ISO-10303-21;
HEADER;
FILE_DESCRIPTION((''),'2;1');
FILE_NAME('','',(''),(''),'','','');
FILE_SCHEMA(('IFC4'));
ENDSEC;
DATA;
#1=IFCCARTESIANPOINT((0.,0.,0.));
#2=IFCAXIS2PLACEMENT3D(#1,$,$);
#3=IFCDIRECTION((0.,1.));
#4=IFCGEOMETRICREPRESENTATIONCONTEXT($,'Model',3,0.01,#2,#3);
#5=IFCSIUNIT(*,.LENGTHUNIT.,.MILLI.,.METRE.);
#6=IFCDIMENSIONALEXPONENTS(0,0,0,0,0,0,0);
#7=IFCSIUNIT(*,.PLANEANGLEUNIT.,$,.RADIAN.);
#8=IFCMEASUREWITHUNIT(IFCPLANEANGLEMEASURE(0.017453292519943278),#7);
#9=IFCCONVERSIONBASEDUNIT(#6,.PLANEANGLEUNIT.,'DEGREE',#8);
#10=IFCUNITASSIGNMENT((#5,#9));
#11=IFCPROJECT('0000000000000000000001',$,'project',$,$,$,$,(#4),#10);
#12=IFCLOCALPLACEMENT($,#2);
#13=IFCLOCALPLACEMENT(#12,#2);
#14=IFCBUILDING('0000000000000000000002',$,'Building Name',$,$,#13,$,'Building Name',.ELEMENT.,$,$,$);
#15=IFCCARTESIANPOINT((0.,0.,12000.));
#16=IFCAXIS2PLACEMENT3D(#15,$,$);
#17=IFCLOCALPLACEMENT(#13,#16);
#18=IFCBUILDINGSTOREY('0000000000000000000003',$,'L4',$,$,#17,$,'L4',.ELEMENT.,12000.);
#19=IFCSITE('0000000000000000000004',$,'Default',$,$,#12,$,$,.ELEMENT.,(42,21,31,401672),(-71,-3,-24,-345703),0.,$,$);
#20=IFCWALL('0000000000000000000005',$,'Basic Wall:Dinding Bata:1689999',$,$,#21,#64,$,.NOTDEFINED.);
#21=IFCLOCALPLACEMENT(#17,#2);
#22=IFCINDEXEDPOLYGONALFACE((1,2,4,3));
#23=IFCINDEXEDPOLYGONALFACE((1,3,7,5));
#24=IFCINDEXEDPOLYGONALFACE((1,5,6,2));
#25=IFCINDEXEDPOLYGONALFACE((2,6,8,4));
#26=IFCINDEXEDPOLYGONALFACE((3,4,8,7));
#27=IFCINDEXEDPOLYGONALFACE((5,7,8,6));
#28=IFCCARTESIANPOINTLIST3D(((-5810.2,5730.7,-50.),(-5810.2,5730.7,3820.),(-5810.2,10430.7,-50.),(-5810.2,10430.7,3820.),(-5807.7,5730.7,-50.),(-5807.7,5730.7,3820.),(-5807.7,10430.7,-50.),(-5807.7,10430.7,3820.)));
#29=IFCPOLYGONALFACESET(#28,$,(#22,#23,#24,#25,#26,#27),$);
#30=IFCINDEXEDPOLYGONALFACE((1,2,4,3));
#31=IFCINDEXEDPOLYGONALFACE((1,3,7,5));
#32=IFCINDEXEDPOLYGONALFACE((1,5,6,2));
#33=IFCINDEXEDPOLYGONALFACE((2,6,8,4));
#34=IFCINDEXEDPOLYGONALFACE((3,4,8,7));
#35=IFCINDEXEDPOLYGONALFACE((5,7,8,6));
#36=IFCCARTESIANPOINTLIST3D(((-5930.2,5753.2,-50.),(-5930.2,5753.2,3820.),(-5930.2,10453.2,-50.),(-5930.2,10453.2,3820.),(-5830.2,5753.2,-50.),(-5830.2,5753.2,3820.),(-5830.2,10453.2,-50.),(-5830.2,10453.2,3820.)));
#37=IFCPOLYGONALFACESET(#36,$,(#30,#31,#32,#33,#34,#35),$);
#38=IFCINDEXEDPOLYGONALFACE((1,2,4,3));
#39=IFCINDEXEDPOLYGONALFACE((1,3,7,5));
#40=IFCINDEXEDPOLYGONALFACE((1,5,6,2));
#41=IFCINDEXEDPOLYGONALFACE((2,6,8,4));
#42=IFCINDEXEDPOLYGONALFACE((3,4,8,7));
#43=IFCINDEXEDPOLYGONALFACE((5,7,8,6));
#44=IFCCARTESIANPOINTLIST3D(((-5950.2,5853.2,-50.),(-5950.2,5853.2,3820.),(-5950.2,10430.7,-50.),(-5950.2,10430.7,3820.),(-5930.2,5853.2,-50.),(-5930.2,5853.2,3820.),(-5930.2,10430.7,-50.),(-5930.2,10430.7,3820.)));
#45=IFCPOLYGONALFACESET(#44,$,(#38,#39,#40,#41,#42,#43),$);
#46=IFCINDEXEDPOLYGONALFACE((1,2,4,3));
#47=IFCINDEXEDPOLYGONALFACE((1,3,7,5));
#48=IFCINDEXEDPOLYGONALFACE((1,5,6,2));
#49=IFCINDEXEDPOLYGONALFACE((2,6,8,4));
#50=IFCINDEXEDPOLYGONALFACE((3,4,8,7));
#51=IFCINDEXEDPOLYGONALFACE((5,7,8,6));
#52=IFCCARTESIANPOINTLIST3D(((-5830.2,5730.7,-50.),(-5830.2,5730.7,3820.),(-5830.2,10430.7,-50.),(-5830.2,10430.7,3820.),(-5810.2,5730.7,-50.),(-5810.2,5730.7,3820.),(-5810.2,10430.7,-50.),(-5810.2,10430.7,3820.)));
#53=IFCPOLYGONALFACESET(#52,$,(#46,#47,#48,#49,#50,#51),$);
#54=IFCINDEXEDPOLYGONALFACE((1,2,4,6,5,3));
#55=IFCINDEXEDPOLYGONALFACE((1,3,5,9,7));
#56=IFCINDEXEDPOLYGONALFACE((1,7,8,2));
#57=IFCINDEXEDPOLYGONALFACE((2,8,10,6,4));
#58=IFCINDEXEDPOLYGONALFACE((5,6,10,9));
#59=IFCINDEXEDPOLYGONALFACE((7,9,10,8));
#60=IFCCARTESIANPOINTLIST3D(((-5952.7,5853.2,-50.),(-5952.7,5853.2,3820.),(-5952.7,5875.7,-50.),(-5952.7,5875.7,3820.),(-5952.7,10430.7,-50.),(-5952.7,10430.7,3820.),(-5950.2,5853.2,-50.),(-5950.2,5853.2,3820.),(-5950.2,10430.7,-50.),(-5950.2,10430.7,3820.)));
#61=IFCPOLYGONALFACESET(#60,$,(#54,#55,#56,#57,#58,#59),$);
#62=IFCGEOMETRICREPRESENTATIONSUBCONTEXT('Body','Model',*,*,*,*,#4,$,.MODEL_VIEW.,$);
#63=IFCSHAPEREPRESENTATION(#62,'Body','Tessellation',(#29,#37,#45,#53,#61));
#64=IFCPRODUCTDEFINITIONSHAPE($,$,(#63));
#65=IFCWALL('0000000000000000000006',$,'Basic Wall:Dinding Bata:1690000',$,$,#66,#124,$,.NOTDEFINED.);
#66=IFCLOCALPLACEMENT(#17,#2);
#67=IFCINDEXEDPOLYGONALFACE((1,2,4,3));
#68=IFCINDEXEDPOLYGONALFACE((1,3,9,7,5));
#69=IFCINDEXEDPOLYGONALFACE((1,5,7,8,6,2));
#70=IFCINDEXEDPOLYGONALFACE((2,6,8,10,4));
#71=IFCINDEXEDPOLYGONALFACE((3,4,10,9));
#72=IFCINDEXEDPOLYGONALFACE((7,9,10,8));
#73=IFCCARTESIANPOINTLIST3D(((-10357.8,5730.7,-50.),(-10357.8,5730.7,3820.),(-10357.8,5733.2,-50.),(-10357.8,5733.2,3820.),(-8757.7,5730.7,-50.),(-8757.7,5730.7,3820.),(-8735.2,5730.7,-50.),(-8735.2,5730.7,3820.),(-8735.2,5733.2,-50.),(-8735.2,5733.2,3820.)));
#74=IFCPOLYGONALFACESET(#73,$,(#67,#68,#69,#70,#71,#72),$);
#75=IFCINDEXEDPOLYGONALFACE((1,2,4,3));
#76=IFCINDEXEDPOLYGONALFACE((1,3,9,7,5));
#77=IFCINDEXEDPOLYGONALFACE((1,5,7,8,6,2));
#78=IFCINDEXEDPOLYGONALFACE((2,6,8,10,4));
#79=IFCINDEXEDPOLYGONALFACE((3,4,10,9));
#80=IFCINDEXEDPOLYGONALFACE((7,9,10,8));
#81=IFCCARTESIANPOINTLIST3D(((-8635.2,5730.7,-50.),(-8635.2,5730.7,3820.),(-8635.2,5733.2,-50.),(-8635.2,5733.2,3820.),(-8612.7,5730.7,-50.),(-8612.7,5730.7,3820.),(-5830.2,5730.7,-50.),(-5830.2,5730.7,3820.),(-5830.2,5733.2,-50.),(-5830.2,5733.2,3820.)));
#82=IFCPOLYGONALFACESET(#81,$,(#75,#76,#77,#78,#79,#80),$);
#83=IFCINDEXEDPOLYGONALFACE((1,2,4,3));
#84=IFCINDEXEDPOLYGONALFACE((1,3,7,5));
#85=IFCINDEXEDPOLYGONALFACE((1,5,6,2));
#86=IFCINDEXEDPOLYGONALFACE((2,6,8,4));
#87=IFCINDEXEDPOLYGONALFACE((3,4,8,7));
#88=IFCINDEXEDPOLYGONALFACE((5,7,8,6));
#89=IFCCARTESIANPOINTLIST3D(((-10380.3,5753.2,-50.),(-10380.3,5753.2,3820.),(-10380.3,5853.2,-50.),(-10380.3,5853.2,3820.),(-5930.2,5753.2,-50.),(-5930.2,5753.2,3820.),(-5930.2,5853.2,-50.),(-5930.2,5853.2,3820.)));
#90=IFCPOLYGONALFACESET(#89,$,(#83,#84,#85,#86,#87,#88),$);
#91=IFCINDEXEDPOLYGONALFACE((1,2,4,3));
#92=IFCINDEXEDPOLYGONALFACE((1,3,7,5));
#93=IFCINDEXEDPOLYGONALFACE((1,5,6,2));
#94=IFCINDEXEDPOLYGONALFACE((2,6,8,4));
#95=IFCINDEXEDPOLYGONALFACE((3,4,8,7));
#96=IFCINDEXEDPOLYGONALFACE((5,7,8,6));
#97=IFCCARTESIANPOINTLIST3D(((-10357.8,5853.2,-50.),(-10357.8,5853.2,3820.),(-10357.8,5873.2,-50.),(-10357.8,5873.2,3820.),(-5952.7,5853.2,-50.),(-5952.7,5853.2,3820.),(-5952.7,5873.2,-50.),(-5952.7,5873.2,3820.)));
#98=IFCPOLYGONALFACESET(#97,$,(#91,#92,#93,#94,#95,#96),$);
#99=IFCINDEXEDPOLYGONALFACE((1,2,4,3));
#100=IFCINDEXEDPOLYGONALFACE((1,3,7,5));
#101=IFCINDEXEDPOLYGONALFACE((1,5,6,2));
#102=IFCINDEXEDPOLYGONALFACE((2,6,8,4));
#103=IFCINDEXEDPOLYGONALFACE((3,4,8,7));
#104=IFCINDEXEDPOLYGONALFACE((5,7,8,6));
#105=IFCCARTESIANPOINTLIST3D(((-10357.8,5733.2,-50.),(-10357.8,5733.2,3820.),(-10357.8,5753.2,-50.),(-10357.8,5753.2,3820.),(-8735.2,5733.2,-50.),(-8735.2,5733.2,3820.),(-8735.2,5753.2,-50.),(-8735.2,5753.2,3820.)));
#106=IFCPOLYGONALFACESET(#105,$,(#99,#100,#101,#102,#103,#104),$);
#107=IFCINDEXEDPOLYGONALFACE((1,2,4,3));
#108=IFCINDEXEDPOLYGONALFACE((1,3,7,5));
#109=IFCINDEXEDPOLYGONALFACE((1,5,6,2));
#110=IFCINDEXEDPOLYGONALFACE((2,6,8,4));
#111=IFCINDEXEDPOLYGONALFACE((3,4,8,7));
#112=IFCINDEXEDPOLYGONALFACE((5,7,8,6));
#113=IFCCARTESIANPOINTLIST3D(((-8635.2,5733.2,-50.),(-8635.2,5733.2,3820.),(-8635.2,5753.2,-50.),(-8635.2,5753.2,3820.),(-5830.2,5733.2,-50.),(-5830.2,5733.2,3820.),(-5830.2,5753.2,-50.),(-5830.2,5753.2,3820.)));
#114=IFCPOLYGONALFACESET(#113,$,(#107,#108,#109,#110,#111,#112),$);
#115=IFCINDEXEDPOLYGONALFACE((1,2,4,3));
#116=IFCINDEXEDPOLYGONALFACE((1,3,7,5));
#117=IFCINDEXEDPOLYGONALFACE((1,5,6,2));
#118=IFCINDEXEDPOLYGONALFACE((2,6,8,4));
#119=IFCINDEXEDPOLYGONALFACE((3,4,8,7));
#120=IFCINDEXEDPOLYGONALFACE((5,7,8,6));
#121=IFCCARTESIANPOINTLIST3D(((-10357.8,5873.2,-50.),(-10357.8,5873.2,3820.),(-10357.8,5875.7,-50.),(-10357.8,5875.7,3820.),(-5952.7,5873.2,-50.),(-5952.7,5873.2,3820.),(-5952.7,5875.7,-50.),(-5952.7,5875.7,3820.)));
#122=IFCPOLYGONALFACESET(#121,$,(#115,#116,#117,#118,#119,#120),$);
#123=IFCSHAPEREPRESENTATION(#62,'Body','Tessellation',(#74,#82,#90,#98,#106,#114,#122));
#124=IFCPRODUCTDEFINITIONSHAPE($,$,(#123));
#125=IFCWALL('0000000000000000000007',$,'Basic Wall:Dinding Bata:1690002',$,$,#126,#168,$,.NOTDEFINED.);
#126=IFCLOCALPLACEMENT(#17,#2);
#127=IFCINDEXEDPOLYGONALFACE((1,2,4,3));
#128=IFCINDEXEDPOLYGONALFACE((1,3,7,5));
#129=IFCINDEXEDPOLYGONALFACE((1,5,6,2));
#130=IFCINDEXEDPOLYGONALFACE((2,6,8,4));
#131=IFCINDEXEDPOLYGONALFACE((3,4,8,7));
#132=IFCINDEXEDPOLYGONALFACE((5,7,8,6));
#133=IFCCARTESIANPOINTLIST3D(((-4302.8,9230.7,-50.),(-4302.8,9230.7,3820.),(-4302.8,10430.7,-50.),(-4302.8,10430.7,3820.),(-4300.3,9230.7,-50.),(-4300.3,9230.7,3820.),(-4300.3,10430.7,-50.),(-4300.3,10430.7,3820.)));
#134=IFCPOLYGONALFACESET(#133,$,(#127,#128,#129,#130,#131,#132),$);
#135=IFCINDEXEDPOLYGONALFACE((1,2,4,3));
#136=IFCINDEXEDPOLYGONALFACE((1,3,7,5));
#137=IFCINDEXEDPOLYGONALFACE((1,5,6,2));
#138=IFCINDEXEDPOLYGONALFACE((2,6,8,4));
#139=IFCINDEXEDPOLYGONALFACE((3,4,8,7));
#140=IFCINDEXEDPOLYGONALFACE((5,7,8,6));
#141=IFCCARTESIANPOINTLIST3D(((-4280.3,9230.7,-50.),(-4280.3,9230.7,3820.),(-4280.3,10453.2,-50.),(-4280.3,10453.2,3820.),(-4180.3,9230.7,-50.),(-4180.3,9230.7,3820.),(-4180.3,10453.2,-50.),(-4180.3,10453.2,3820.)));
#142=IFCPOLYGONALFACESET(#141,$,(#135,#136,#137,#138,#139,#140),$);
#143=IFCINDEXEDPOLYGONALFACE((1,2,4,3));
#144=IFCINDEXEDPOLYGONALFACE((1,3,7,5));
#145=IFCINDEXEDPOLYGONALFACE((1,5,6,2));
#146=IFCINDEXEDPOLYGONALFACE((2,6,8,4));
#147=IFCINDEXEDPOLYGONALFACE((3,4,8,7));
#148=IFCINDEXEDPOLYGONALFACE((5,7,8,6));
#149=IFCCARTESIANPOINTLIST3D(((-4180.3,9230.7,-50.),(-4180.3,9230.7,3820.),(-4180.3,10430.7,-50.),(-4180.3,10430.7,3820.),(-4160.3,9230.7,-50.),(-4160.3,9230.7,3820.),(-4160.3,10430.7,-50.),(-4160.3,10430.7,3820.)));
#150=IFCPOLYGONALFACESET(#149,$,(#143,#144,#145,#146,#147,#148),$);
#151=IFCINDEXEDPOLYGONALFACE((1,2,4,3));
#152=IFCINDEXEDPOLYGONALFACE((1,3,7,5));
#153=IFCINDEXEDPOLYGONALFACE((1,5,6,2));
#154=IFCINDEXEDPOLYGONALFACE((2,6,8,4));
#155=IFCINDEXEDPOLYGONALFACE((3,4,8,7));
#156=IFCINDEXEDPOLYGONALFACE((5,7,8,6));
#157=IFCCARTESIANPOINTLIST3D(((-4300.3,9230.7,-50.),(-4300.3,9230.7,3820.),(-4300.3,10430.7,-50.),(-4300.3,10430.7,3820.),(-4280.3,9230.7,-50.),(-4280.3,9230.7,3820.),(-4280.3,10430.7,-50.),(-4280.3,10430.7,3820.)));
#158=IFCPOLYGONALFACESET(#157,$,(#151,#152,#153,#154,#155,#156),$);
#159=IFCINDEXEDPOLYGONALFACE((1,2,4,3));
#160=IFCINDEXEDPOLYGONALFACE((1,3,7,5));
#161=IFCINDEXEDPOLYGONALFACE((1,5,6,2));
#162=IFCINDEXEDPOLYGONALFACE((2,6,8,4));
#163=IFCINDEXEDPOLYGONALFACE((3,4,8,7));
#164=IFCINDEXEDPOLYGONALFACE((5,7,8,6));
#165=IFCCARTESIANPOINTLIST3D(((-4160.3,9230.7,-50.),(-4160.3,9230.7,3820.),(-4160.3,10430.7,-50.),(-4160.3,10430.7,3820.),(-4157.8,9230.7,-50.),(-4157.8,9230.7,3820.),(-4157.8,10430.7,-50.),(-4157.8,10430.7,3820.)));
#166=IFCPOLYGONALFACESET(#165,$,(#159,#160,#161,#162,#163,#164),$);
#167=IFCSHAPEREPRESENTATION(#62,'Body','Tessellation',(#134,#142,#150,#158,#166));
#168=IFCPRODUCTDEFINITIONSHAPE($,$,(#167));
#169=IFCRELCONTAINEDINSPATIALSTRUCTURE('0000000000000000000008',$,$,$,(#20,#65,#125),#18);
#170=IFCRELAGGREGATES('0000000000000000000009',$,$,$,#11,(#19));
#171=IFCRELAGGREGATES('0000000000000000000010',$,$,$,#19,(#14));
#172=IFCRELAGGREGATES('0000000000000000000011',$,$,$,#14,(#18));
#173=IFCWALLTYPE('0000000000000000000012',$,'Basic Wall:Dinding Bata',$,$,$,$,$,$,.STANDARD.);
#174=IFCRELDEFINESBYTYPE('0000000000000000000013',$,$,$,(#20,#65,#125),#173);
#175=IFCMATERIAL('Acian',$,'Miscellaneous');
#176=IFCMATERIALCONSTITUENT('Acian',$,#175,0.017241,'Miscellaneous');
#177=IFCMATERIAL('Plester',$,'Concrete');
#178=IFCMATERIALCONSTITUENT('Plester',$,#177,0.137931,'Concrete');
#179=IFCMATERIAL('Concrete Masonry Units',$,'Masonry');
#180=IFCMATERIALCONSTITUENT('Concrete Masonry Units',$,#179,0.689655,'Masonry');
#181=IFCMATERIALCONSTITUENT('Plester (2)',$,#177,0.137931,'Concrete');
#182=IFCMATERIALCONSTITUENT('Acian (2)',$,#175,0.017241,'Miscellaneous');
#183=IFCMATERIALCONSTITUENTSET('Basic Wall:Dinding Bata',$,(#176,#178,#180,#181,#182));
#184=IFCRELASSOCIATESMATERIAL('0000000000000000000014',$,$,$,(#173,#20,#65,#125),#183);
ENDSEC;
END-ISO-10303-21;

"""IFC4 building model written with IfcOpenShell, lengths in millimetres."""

from ifc_helpers import new_model, entity, si_unit, converted_unit, direction, frame, origin, place, context, subcontext, project, spatial, indexed_curve, outline, extrude, material, constituent, constituent_set, type_object, element, save


model = new_model("IFC4")

# Units and contexts
model_context = context("Model", 3, precision=0.01, world=origin(), true_north=direction((0.0, 1.0)))
body_context = subcontext(model_context, "Body", "Model", "MODEL_VIEW")
ifc_project = project(units=[si_unit("LENGTHUNIT", "METRE", prefix="MILLI"), converted_unit("PLANEANGLEUNIT", "DEGREE", entity("IfcPlaneAngleMeasure", 0.017453292519943278), si_unit("PLANEANGLEUNIT", "RADIAN"), dimensions=[0, 0, 0, 0, 0, 0, 0])], contexts=[model_context])

# Site, building, storey
site_placement = place(None, origin())
site = spatial("IfcSite", under=ifc_project, at=site_placement, Name="Default", CompositionType="ELEMENT", RefLatitude=(42, 21, 31, 401672), RefLongitude=(-71, -3, -24, -345703), RefElevation=0.0)
building_placement = place(site_placement, origin())
building = spatial("IfcBuilding", under=site, at=building_placement, Name="Building Name", LongName="Building Name", CompositionType="ELEMENT")
storey_placement = place(building_placement, frame((0.0, 0.0, 12000.0)))
storey = spatial("IfcBuildingStorey", under=building, at=storey_placement, Name="L4", LongName="L4", CompositionType="ELEMENT", Elevation=12000.0)

# Walls
ifc_material_1 = material(Name="Acian", Category="Miscellaneous")
ifc_constituent_1 = constituent(ifc_material_1, Name="Acian", Category="Miscellaneous", fraction=0.017241)
ifc_material_2 = material(Name="Plester", Category="Concrete")
ifc_constituent_2 = constituent(ifc_material_2, Name="Plester", Category="Concrete", fraction=0.137931)
ifc_material_3 = material(Name="Concrete Masonry Units", Category="Masonry")
ifc_constituent_3 = constituent(ifc_material_3, Name="Concrete Masonry Units", Category="Masonry", fraction=0.689655)
ifc_constituent_4 = constituent(ifc_material_2, Name="Plester (2)", Category="Concrete", fraction=0.137931)
ifc_constituent_5 = constituent(ifc_material_1, Name="Acian (2)", Category="Miscellaneous", fraction=0.017241)
ifc_constituent_set = constituent_set(constituents=[ifc_constituent_1, ifc_constituent_2, ifc_constituent_3, ifc_constituent_4, ifc_constituent_5], Name="Basic Wall:Dinding Bata")
wall_type = type_object("IfcWallType", Name="Basic Wall:Dinding Bata", PredefinedType="STANDARD", material=ifc_constituent_set)
wall_1_placement = place(storey_placement, frame((-5880.2, 10430.7, -50.0), z_axis=(0.0, 0.0, 1.0), x_axis=(0.0, -1.0, 0.0)))
element("IfcWall", 1, at=wall_1_placement, inside=storey, type_object=wall_type, material=ifc_constituent_set, Name="Basic Wall:Dinding Bata:1689999", PredefinedType="NOTDEFINED", context=body_context, shape_type="SweptSolid", body=[
    extrude(outline(indexed_curve([(-1.3, -2350.0), (1.2, -2350.0), (1.3, 2350.0), (-1.2, 2350.0), (-1.3, -2350.0)], self_intersect=False)), frame((2350.0, 71.3, 0.0), z_axis=(0.0, 0.0, 1.0), x_axis=(0.0, -1.0, 0.0)), (0.0, 0.0, 1.0), 3870.0),
    extrude(outline(indexed_curve([(-2350.0, -50.0), (2350.0, -50.0), (2350.0, 50.0), (-2350.0, 50.0), (-2350.0, -50.0)], self_intersect=False)), frame((2327.5, 0.0, 0.0)), (0.0, 0.0, 1.0), 3870.0),
    extrude(outline(indexed_curve([(-2288.8, -10.0), (2288.8, -10.0), (2288.8, 10.0), (-2288.8, 10.0), (-2288.8, -10.0)], self_intersect=False)), frame((2288.8, -60.0, 0.0)), (0.0, 0.0, 1.0), 3870.0),
    extrude(outline(indexed_curve([(-2350.0, -10.0), (2350.0, -10.0), (2350.0, 10.0), (-2350.0, 10.0), (-2350.0, -10.0)], self_intersect=False)), frame((2350.0, 60.0, 0.0)), (0.0, 0.0, 1.0), 3870.0),
    extrude(outline(indexed_curve([(1813.0, -1.0), (1835.5, -1.0), (1835.5, 1.5), (-2742.0, 1.5), (-2742.0, -1.0), (1813.0, -1.0)], self_intersect=False)), frame((2742.0, -71.5, 0.0)), (0.0, 0.0, 1.0), 3870.0),
])
wall_2_placement = place(storey_placement, frame((-5952.7, 5803.2, -50.0), z_axis=(0.0, 0.0, 1.0), x_axis=(-1.0, 0.0, 0.0)))
element("IfcWall", 2, at=wall_2_placement, inside=storey, type_object=wall_type, material=ifc_constituent_set, Name="Basic Wall:Dinding Bata:1690000", PredefinedType="NOTDEFINED", context=body_context, shape_type="SweptSolid", body=[
    extrude(outline(indexed_curve([(631.0, -1.0), (653.5, -1.0), (653.5, 1.5), (-969.0, 1.5), (-969.0, -1.0), (631.0, -1.0)], self_intersect=False)), frame((3436.0, 71.5, 0.0), z_axis=(0.0, 0.0, 1.0), x_axis=(-1.0, 0.0, 0.0)), (0.0, 0.0, 1.0), 3870.0),
    extrude(outline(indexed_curve([(-1.0, -1678.5), (1.5, -1678.5), (1.5, 1126.5), (-1.0, 1126.5), (-1.0, 1104.0), (-1.0, -1678.5)], self_intersect=False)), frame((1556.0, 71.5, 0.0), z_axis=(0.0, 0.0, 1.0), x_axis=(0.0, -1.0, 0.0)), (0.0, 0.0, 1.0), 3870.0),
    extrude(outline(indexed_curve([(-2225.0, -50.0), (2225.0, -50.0), (2225.0, 50.0), (-2225.0, 50.0), (-2225.0, -50.0)], self_intersect=False)), frame((2202.5, 0.0, 0.0)), (0.0, 0.0, 1.0), 3870.0),
    extrude(outline(indexed_curve([(-2202.5, -10.0), (2202.5, -10.0), (2202.5, 10.0), (-2202.5, 10.0), (-2202.5, -10.0)], self_intersect=False)), frame((2202.5, -60.0, 0.0)), (0.0, 0.0, 1.0), 3870.0),
    extrude(outline(indexed_curve([(-811.3, -10.0), (811.3, -10.0), (811.3, 10.0), (-811.3, 10.0), (-811.3, -10.0)], self_intersect=False)), frame((3593.8, 60.0, 0.0), z_axis=(0.0, 0.0, 1.0), x_axis=(-1.0, 0.0, 0.0)), (0.0, 0.0, 1.0), 3870.0),
    extrude(outline(indexed_curve([(-1402.5, -10.0), (1402.5, -10.0), (1402.5, 10.0), (-1402.5, 10.0), (-1402.5, -10.0)], self_intersect=False)), frame((1280.0, 60.0, 0.0)), (0.0, 0.0, 1.0), 3870.0),
    extrude(outline(indexed_curve([(-1.3, -2202.5), (1.2, -2202.5), (1.3, 2202.5), (-1.2, 2202.5), (-1.3, -2202.5)], self_intersect=False)), frame((2202.5, -71.3, 0.0), z_axis=(0.0, 0.0, 1.0), x_axis=(0.0, 1.0, 0.0)), (0.0, 0.0, 1.0), 3870.0),
])
wall_3_placement = place(storey_placement, frame((-4230.3, 9230.7, -50.0), z_axis=(0.0, 0.0, 1.0), x_axis=(0.0, 1.0, 0.0)))
element("IfcWall", 3, at=wall_3_placement, inside=storey, type_object=wall_type, material=ifc_constituent_set, Name="Basic Wall:Dinding Bata:1690002", PredefinedType="NOTDEFINED", context=body_context, shape_type="SweptSolid", body=[
    extrude(outline(indexed_curve([(-1.3, -600.0), (1.2, -600.0), (1.3, 600.0), (-1.2, 600.0), (-1.3, -600.0)], self_intersect=False)), frame((600.0, 71.3, 0.0), z_axis=(0.0, 0.0, 1.0), x_axis=(0.0, -1.0, 0.0)), (0.0, 0.0, 1.0), 3870.0),
    extrude(outline(indexed_curve([(-611.3, -50.0), (611.3, -50.0), (611.3, 50.0), (-611.3, 50.0), (-611.3, -50.0)], self_intersect=False)), frame((611.3, 0.0, 0.0)), (0.0, 0.0, 1.0), 3870.0),
    extrude(outline(indexed_curve([(-600.0, -10.0), (600.0, -10.0), (600.0, 10.0), (-600.0, 10.0), (-600.0, -10.0)], self_intersect=False)), frame((600.0, -60.0, 0.0)), (0.0, 0.0, 1.0), 3870.0),
    extrude(outline(indexed_curve([(-600.0, -10.0), (600.0, -10.0), (600.0, 10.0), (-600.0, 10.0), (-600.0, -10.0)], self_intersect=False)), frame((600.0, 60.0, 0.0)), (0.0, 0.0, 1.0), 3870.0),
    extrude(outline(indexed_curve([(-1.3, -600.0), (1.2, -600.0), (1.3, 600.0), (-1.2, 600.0), (-1.3, -600.0)], self_intersect=False)), frame((600.0, -71.2, 0.0), z_axis=(0.0, 0.0, 1.0), x_axis=(0.0, 1.0, 0.0)), (0.0, 0.0, 1.0), 3870.0),
])

save(model, "model.ifc")
